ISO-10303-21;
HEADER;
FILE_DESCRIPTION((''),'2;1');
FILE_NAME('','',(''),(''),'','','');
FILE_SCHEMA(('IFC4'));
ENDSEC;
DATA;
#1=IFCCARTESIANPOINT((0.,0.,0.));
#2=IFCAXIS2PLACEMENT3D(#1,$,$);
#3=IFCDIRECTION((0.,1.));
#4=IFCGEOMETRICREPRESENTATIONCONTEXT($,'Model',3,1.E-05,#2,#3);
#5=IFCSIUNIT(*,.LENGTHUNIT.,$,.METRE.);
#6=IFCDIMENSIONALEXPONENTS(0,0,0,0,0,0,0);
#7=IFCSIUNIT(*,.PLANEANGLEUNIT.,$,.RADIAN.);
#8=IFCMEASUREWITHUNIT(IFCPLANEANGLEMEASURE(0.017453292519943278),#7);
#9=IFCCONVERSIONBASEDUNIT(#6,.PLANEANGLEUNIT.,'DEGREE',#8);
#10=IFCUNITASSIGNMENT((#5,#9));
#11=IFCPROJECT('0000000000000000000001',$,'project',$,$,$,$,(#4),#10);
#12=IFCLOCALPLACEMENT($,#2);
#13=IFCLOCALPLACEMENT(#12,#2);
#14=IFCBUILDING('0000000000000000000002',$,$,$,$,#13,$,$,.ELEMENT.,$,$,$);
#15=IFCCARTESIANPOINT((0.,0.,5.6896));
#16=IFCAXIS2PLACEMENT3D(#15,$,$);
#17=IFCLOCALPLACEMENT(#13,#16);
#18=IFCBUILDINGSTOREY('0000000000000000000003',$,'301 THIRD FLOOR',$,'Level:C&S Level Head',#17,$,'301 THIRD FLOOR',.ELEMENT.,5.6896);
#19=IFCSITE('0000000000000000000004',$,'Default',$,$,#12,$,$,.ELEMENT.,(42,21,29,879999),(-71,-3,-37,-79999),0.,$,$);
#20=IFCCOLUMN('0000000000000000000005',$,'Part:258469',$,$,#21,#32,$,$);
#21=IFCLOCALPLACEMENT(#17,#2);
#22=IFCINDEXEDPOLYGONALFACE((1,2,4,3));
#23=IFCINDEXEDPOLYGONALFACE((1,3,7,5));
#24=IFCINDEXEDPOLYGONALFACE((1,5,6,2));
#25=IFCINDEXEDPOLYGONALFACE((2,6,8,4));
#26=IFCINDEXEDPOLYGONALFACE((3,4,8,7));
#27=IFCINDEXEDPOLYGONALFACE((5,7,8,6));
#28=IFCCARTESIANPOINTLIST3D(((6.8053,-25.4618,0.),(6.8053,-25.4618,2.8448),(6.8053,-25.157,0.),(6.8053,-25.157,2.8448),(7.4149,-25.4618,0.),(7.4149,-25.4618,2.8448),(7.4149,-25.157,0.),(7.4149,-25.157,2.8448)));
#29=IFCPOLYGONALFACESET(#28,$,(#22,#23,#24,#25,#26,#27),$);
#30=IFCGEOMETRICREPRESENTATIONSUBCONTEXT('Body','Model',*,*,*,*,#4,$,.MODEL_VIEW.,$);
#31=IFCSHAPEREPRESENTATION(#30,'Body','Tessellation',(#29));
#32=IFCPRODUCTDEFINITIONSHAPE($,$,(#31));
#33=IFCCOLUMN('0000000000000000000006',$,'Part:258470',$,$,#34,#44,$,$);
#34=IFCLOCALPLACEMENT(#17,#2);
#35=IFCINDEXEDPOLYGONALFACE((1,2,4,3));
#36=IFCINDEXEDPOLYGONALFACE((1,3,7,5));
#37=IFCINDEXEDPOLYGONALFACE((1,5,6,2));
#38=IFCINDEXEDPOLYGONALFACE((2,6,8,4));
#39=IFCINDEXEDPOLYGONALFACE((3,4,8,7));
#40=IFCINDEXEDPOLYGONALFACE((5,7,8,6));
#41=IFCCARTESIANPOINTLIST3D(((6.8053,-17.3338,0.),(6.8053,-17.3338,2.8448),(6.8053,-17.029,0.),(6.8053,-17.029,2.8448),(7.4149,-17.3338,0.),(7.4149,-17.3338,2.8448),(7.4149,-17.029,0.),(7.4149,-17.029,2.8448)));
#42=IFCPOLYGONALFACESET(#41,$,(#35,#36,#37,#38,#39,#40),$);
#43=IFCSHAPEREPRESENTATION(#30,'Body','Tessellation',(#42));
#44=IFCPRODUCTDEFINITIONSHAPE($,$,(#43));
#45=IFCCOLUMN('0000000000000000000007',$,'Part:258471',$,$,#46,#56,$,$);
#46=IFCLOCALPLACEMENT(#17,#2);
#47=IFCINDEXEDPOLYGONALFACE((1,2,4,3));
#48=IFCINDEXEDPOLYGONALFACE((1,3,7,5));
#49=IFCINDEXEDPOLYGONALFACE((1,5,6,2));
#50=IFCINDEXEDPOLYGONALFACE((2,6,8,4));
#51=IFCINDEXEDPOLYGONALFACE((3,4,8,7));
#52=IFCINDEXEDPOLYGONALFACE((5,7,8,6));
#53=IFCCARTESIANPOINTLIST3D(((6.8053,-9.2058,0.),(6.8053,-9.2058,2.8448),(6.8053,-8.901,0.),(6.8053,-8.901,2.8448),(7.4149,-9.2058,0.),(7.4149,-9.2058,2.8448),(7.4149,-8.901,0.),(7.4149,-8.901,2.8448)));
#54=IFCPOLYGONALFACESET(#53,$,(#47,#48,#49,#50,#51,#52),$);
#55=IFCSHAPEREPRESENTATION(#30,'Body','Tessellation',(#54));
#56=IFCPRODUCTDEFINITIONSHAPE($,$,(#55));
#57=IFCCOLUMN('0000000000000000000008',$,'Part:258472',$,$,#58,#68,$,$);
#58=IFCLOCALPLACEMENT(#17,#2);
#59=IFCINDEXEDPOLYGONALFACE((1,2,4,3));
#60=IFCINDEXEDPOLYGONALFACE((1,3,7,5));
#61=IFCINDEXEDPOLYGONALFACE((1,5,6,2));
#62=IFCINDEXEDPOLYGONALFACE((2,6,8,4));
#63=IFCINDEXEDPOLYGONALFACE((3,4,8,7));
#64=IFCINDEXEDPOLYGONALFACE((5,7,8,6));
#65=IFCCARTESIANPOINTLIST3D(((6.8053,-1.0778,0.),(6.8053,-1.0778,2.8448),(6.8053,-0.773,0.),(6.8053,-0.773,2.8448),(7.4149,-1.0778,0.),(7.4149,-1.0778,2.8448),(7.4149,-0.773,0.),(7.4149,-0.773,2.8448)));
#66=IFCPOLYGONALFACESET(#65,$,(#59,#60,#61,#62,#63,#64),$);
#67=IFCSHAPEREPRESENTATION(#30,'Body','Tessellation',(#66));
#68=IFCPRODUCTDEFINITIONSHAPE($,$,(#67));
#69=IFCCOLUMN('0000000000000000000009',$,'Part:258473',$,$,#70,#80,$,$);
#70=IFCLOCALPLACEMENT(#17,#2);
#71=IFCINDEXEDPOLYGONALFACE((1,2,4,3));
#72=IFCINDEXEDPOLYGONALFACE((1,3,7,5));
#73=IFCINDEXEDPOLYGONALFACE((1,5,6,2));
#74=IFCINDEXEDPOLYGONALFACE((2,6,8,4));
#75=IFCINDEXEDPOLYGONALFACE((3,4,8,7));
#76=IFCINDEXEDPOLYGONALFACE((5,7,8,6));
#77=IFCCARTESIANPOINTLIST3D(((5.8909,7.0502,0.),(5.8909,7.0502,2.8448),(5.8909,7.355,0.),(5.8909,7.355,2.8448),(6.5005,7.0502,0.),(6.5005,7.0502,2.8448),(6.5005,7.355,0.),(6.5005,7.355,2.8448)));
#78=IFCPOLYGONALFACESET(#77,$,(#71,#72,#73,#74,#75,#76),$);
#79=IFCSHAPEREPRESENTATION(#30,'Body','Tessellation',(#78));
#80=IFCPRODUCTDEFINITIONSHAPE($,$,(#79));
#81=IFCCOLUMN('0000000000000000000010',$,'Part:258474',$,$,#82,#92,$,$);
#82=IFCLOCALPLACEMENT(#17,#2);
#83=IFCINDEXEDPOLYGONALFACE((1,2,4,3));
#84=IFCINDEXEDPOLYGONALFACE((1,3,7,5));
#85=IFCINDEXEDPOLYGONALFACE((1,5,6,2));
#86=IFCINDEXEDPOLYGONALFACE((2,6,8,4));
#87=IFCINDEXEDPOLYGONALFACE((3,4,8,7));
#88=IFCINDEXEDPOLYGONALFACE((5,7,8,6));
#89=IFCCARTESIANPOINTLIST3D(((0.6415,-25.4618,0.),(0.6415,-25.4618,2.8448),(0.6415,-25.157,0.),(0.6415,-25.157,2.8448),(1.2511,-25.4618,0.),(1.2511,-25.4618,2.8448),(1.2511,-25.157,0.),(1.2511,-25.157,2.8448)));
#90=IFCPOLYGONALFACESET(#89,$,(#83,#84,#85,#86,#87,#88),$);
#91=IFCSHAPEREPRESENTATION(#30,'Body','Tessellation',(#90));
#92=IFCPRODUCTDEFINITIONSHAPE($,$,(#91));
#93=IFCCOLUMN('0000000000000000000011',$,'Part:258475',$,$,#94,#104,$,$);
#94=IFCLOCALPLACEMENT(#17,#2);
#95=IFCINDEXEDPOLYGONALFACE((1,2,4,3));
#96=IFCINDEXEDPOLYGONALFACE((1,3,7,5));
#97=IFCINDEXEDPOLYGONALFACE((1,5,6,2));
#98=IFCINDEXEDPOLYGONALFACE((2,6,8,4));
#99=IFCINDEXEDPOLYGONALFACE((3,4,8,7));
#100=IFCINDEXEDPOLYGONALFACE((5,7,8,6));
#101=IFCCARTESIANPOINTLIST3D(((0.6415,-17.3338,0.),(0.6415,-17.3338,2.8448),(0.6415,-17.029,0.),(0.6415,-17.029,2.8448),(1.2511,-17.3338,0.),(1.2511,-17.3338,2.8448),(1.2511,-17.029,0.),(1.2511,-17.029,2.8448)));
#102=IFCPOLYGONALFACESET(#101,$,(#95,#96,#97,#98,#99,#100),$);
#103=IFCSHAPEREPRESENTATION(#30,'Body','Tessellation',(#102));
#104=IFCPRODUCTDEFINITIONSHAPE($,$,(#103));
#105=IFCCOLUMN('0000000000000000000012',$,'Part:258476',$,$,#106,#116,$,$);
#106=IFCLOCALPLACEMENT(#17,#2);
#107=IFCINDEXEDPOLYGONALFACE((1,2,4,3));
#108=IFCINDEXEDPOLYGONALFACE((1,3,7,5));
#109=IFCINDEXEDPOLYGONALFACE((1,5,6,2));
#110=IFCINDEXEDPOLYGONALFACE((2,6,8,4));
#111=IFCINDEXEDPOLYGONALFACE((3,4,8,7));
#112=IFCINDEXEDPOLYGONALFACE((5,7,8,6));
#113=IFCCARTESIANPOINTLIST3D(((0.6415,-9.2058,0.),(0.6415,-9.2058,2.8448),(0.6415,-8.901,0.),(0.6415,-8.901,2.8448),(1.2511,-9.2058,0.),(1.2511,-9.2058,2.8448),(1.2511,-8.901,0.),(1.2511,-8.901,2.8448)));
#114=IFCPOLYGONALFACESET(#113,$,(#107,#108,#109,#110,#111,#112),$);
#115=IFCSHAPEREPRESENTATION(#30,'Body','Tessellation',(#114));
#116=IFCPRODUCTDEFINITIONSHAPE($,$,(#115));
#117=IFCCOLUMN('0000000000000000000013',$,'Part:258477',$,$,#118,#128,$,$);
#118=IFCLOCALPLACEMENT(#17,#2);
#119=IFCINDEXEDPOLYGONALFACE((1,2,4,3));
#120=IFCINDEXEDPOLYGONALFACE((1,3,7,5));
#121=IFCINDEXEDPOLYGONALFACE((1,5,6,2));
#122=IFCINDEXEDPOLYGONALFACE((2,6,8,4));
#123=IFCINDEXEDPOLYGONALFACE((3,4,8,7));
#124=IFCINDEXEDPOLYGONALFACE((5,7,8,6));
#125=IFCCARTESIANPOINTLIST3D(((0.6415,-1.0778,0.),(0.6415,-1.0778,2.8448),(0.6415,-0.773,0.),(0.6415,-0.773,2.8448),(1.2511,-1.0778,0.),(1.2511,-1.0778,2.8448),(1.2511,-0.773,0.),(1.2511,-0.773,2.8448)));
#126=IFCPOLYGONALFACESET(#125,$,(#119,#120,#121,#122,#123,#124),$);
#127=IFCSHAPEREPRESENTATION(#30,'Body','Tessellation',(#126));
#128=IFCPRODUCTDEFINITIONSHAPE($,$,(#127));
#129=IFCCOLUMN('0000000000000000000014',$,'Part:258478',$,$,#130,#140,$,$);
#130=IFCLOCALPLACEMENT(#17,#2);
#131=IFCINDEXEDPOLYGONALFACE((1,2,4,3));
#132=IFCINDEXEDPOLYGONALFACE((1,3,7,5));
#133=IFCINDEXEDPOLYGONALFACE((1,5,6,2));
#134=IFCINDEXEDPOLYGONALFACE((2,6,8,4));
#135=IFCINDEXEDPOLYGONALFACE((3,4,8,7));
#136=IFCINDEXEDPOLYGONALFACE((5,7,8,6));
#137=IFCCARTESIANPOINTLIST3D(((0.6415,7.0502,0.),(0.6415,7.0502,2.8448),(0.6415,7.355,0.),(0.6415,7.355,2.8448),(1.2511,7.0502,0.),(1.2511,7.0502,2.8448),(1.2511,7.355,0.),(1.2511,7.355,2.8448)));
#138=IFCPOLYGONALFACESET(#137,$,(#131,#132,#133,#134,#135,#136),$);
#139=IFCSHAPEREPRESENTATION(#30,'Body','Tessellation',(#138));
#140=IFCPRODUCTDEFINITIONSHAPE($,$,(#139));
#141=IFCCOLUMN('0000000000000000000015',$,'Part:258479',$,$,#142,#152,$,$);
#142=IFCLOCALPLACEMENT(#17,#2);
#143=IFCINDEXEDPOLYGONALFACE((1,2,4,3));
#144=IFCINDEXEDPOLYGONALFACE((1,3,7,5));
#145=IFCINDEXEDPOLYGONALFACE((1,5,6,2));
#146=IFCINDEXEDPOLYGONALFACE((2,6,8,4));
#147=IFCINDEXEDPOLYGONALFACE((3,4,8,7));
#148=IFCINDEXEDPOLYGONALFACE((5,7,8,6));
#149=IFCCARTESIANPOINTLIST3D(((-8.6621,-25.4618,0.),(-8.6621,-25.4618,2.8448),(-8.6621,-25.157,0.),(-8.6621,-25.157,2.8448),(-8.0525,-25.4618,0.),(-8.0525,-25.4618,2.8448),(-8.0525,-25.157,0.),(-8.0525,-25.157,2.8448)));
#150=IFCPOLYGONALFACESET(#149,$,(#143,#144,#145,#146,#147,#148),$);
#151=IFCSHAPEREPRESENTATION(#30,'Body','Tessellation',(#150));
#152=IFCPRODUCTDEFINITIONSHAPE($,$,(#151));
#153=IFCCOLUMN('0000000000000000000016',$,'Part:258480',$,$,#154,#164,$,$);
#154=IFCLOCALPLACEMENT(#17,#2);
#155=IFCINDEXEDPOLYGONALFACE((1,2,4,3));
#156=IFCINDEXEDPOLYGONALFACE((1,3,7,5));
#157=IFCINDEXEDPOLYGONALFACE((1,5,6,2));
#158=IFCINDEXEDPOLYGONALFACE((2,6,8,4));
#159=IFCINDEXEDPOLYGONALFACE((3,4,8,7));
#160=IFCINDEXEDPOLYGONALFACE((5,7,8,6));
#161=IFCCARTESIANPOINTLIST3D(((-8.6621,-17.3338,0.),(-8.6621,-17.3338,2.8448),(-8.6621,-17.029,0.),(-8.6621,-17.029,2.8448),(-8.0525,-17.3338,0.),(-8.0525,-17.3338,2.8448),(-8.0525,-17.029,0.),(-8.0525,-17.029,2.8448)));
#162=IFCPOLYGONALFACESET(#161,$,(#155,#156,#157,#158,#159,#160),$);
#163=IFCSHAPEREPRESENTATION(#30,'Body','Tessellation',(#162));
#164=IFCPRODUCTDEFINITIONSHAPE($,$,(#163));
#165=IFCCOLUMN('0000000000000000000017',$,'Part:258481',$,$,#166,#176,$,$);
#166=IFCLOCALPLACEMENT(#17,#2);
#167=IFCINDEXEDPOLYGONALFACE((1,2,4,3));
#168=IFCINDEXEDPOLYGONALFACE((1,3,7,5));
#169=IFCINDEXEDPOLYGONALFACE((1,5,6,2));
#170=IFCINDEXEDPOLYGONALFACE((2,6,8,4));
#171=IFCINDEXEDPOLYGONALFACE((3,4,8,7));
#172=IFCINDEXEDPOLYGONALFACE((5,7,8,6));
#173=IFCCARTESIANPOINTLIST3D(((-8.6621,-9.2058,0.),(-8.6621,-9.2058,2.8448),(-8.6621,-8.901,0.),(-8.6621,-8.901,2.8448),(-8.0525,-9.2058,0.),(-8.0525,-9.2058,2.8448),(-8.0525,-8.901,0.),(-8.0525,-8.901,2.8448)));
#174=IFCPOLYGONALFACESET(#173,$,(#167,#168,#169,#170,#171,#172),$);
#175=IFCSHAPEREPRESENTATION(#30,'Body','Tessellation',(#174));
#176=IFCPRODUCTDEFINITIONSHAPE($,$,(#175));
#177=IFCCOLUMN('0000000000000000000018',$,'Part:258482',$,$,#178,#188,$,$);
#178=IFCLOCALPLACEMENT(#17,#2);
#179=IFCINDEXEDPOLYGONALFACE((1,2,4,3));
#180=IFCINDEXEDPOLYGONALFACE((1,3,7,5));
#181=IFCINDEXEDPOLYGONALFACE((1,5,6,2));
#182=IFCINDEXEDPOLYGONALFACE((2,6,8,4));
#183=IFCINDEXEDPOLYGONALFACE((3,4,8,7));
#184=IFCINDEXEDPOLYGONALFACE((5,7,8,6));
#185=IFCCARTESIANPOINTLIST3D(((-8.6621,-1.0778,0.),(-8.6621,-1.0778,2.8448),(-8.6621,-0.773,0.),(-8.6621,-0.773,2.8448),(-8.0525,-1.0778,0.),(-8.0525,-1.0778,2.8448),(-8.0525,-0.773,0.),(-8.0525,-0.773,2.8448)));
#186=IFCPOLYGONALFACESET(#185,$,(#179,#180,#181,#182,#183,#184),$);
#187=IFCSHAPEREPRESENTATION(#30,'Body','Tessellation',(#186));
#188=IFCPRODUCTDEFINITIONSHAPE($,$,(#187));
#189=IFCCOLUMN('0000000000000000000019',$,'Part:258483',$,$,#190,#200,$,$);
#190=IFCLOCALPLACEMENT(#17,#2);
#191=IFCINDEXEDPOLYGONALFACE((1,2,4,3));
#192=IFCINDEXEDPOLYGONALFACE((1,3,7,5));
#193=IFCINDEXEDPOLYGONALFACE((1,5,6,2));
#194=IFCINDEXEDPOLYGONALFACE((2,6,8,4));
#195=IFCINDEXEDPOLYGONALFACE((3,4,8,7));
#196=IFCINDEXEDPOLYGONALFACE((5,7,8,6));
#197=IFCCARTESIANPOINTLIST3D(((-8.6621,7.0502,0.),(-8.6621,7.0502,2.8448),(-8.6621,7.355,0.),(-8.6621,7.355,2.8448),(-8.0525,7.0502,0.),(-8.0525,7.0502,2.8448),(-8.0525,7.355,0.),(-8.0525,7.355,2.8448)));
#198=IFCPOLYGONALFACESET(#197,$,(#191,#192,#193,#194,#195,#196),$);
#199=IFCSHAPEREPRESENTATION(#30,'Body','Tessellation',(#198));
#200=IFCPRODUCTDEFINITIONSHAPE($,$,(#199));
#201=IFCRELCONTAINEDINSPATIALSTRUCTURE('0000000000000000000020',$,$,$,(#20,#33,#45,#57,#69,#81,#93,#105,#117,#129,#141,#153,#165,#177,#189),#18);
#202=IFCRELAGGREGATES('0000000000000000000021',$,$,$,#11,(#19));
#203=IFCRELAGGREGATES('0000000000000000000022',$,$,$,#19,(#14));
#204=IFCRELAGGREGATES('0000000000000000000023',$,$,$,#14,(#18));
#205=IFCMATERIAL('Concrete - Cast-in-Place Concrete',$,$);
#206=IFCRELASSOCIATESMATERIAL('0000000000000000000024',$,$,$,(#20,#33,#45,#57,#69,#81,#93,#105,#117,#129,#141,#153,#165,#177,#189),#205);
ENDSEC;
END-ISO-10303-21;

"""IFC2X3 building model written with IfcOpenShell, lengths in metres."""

from ifc_helpers import new_model, entity, si_unit, converted_unit, direction, frame, frame_2d, origin, place, context, subcontext, project, spatial, rectangle, extrude, material, element, save


model = new_model("IFC2X3")

# Units and contexts
model_context = context("Model", 3, precision=1e-05, world=origin(), true_north=direction((0.0, 1.0)))
body_context = subcontext(model_context, "Body", "Model", "MODEL_VIEW")
ifc_project = project(units=[si_unit("LENGTHUNIT", "METRE"), converted_unit("PLANEANGLEUNIT", "DEGREE", entity("IfcPlaneAngleMeasure", 0.017453292519943278), si_unit("PLANEANGLEUNIT", "RADIAN"), dimensions=[0, 0, 0, 0, 0, 0, 0])], contexts=[model_context])

# Site, building, storey
site_placement = place(None, origin())
site = spatial("IfcSite", under=ifc_project, at=site_placement, Name="Default", CompositionType="ELEMENT", RefLatitude=(42, 21, 29, 879999), RefLongitude=(-71, -3, -37, -79999), RefElevation=0.0)
building_placement = place(site_placement, origin())
building = spatial("IfcBuilding", under=site, at=building_placement, CompositionType="ELEMENT")
storey_placement = place(building_placement, frame((0.0, 0.0, 5.6896)))
storey = spatial("IfcBuildingStorey", under=building, at=storey_placement, Name="301 THIRD FLOOR", ObjectType="Level:C&S Level Head", LongName="301 THIRD FLOOR", CompositionType="ELEMENT", Elevation=5.6896)

# Columns
ifc_material_1 = material(Name="Concrete - Cast-in-Place Concrete")
column_1_placement = place(storey_placement, origin())
element("IfcColumn", 1, at=column_1_placement, inside=storey, material=ifc_material_1, Name="Part:258469", context=body_context, shape_type="SweptSolid", body=[
    extrude(rectangle(XDim=2.8448, YDim=0.3048, at=frame_2d((0.0, 0.0), x_axis=(1.0, 0.0))), frame((6.8053, -25.3094, 1.4224), z_axis=(1.0, 0.0, 0.0), x_axis=(0.0, 0.0, -1.0)), (0.0, 0.0, 1.0), 0.6096),
])
column_2_placement = place(storey_placement, origin())
element("IfcColumn", 2, at=column_2_placement, inside=storey, material=ifc_material_1, Name="Part:258470", context=body_context, shape_type="SweptSolid", body=[
    extrude(rectangle(XDim=2.8448, YDim=0.3048, at=frame_2d((0.0, 0.0), x_axis=(1.0, 0.0))), frame((6.8053, -17.1814, 1.4224), z_axis=(1.0, 0.0, 0.0), x_axis=(0.0, 0.0, -1.0)), (0.0, 0.0, 1.0), 0.6096),
])
column_3_placement = place(storey_placement, origin())
element("IfcColumn", 3, at=column_3_placement, inside=storey, material=ifc_material_1, Name="Part:258471", context=body_context, shape_type="SweptSolid", body=[
    extrude(rectangle(XDim=2.8448, YDim=0.3048, at=frame_2d((0.0, 0.0), x_axis=(1.0, 0.0))), frame((6.8053, -9.0534, 1.4224), z_axis=(1.0, 0.0, 0.0), x_axis=(0.0, 0.0, -1.0)), (0.0, 0.0, 1.0), 0.6096),
])
column_4_placement = place(storey_placement, origin())
element("IfcColumn", 4, at=column_4_placement, inside=storey, material=ifc_material_1, Name="Part:258472", context=body_context, shape_type="SweptSolid", body=[
    extrude(rectangle(XDim=2.8448, YDim=0.3048, at=frame_2d((0.0, 0.0), x_axis=(1.0, 0.0))), frame((6.8053, -0.9254, 1.4224), z_axis=(1.0, 0.0, 0.0), x_axis=(0.0, 0.0, -1.0)), (0.0, 0.0, 1.0), 0.6096),
])
column_5_placement = place(storey_placement, origin())
element("IfcColumn", 5, at=column_5_placement, inside=storey, material=ifc_material_1, Name="Part:258473", context=body_context, shape_type="SweptSolid", body=[
    extrude(rectangle(XDim=2.8448, YDim=0.3048, at=frame_2d((0.0, 0.0), x_axis=(1.0, 0.0))), frame((5.8909, 7.2026, 1.4224), z_axis=(1.0, 0.0, 0.0), x_axis=(0.0, 0.0, -1.0)), (0.0, 0.0, 1.0), 0.6096),
])
column_6_placement = place(storey_placement, origin())
element("IfcColumn", 6, at=column_6_placement, inside=storey, material=ifc_material_1, Name="Part:258474", context=body_context, shape_type="SweptSolid", body=[
    extrude(rectangle(XDim=2.8448, YDim=0.3048, at=frame_2d((0.0, 0.0), x_axis=(1.0, 0.0))), frame((0.6415, -25.3094, 1.4224), z_axis=(1.0, 0.0, 0.0), x_axis=(0.0, 0.0, -1.0)), (0.0, 0.0, 1.0), 0.6096),
])
column_7_placement = place(storey_placement, origin())
element("IfcColumn", 7, at=column_7_placement, inside=storey, material=ifc_material_1, Name="Part:258475", context=body_context, shape_type="SweptSolid", body=[
    extrude(rectangle(XDim=2.8448, YDim=0.3048, at=frame_2d((0.0, 0.0), x_axis=(1.0, 0.0))), frame((0.6415, -17.1814, 1.4224), z_axis=(1.0, 0.0, 0.0), x_axis=(0.0, 0.0, -1.0)), (0.0, 0.0, 1.0), 0.6096),
])
column_8_placement = place(storey_placement, origin())
element("IfcColumn", 8, at=column_8_placement, inside=storey, material=ifc_material_1, Name="Part:258476", context=body_context, shape_type="SweptSolid", body=[
    extrude(rectangle(XDim=2.8448, YDim=0.3048, at=frame_2d((0.0, 0.0), x_axis=(1.0, 0.0))), frame((0.6415, -9.0534, 1.4224), z_axis=(1.0, 0.0, 0.0), x_axis=(0.0, 0.0, -1.0)), (0.0, 0.0, 1.0), 0.6096),
])
column_9_placement = place(storey_placement, origin())
element("IfcColumn", 9, at=column_9_placement, inside=storey, material=ifc_material_1, Name="Part:258477", context=body_context, shape_type="SweptSolid", body=[
    extrude(rectangle(XDim=2.8448, YDim=0.3048, at=frame_2d((0.0, 0.0), x_axis=(1.0, 0.0))), frame((0.6415, -0.9254, 1.4224), z_axis=(1.0, 0.0, 0.0), x_axis=(0.0, 0.0, -1.0)), (0.0, 0.0, 1.0), 0.6096),
])
column_10_placement = place(storey_placement, origin())
element("IfcColumn", 10, at=column_10_placement, inside=storey, material=ifc_material_1, Name="Part:258478", context=body_context, shape_type="SweptSolid", body=[
    extrude(rectangle(XDim=2.8448, YDim=0.3048, at=frame_2d((0.0, 0.0), x_axis=(1.0, 0.0))), frame((0.6415, 7.2026, 1.4224), z_axis=(1.0, 0.0, 0.0), x_axis=(0.0, 0.0, -1.0)), (0.0, 0.0, 1.0), 0.6096),
])
column_11_placement = place(storey_placement, origin())
element("IfcColumn", 11, at=column_11_placement, inside=storey, material=ifc_material_1, Name="Part:258479", context=body_context, shape_type="SweptSolid", body=[
    extrude(rectangle(XDim=2.8448, YDim=0.3048, at=frame_2d((0.0, 0.0), x_axis=(1.0, 0.0))), frame((-8.6621, -25.3094, 1.4224), z_axis=(1.0, 0.0, 0.0), x_axis=(0.0, 0.0, -1.0)), (0.0, 0.0, 1.0), 0.6096),
])
column_12_placement = place(storey_placement, origin())
element("IfcColumn", 12, at=column_12_placement, inside=storey, material=ifc_material_1, Name="Part:258480", context=body_context, shape_type="SweptSolid", body=[
    extrude(rectangle(XDim=2.8448, YDim=0.3048, at=frame_2d((0.0, 0.0), x_axis=(1.0, 0.0))), frame((-8.6621, -17.1814, 1.4224), z_axis=(1.0, 0.0, 0.0), x_axis=(0.0, 0.0, -1.0)), (0.0, 0.0, 1.0), 0.6096),
])
column_13_placement = place(storey_placement, origin())
element("IfcColumn", 13, at=column_13_placement, inside=storey, material=ifc_material_1, Name="Part:258481", context=body_context, shape_type="SweptSolid", body=[
    extrude(rectangle(XDim=2.8448, YDim=0.3048, at=frame_2d((0.0, 0.0), x_axis=(1.0, 0.0))), frame((-8.6621, -9.0534, 1.4224), z_axis=(1.0, 0.0, 0.0), x_axis=(0.0, 0.0, -1.0)), (0.0, 0.0, 1.0), 0.6096),
])
column_14_placement = place(storey_placement, origin())
element("IfcColumn", 14, at=column_14_placement, inside=storey, material=ifc_material_1, Name="Part:258482", context=body_context, shape_type="SweptSolid", body=[
    extrude(rectangle(XDim=2.8448, YDim=0.3048, at=frame_2d((0.0, 0.0), x_axis=(1.0, 0.0))), frame((-8.6621, -0.9254, 1.4224), z_axis=(1.0, 0.0, 0.0), x_axis=(0.0, 0.0, -1.0)), (0.0, 0.0, 1.0), 0.6096),
])
column_15_placement = place(storey_placement, origin())
element("IfcColumn", 15, at=column_15_placement, inside=storey, material=ifc_material_1, Name="Part:258483", context=body_context, shape_type="SweptSolid", body=[
    extrude(rectangle(XDim=2.8448, YDim=0.3048, at=frame_2d((0.0, 0.0), x_axis=(1.0, 0.0))), frame((-8.6621, 7.2026, 1.4224), z_axis=(1.0, 0.0, 0.0), x_axis=(0.0, 0.0, -1.0)), (0.0, 0.0, 1.0), 0.6096),
])

save(model, "model.ifc")
